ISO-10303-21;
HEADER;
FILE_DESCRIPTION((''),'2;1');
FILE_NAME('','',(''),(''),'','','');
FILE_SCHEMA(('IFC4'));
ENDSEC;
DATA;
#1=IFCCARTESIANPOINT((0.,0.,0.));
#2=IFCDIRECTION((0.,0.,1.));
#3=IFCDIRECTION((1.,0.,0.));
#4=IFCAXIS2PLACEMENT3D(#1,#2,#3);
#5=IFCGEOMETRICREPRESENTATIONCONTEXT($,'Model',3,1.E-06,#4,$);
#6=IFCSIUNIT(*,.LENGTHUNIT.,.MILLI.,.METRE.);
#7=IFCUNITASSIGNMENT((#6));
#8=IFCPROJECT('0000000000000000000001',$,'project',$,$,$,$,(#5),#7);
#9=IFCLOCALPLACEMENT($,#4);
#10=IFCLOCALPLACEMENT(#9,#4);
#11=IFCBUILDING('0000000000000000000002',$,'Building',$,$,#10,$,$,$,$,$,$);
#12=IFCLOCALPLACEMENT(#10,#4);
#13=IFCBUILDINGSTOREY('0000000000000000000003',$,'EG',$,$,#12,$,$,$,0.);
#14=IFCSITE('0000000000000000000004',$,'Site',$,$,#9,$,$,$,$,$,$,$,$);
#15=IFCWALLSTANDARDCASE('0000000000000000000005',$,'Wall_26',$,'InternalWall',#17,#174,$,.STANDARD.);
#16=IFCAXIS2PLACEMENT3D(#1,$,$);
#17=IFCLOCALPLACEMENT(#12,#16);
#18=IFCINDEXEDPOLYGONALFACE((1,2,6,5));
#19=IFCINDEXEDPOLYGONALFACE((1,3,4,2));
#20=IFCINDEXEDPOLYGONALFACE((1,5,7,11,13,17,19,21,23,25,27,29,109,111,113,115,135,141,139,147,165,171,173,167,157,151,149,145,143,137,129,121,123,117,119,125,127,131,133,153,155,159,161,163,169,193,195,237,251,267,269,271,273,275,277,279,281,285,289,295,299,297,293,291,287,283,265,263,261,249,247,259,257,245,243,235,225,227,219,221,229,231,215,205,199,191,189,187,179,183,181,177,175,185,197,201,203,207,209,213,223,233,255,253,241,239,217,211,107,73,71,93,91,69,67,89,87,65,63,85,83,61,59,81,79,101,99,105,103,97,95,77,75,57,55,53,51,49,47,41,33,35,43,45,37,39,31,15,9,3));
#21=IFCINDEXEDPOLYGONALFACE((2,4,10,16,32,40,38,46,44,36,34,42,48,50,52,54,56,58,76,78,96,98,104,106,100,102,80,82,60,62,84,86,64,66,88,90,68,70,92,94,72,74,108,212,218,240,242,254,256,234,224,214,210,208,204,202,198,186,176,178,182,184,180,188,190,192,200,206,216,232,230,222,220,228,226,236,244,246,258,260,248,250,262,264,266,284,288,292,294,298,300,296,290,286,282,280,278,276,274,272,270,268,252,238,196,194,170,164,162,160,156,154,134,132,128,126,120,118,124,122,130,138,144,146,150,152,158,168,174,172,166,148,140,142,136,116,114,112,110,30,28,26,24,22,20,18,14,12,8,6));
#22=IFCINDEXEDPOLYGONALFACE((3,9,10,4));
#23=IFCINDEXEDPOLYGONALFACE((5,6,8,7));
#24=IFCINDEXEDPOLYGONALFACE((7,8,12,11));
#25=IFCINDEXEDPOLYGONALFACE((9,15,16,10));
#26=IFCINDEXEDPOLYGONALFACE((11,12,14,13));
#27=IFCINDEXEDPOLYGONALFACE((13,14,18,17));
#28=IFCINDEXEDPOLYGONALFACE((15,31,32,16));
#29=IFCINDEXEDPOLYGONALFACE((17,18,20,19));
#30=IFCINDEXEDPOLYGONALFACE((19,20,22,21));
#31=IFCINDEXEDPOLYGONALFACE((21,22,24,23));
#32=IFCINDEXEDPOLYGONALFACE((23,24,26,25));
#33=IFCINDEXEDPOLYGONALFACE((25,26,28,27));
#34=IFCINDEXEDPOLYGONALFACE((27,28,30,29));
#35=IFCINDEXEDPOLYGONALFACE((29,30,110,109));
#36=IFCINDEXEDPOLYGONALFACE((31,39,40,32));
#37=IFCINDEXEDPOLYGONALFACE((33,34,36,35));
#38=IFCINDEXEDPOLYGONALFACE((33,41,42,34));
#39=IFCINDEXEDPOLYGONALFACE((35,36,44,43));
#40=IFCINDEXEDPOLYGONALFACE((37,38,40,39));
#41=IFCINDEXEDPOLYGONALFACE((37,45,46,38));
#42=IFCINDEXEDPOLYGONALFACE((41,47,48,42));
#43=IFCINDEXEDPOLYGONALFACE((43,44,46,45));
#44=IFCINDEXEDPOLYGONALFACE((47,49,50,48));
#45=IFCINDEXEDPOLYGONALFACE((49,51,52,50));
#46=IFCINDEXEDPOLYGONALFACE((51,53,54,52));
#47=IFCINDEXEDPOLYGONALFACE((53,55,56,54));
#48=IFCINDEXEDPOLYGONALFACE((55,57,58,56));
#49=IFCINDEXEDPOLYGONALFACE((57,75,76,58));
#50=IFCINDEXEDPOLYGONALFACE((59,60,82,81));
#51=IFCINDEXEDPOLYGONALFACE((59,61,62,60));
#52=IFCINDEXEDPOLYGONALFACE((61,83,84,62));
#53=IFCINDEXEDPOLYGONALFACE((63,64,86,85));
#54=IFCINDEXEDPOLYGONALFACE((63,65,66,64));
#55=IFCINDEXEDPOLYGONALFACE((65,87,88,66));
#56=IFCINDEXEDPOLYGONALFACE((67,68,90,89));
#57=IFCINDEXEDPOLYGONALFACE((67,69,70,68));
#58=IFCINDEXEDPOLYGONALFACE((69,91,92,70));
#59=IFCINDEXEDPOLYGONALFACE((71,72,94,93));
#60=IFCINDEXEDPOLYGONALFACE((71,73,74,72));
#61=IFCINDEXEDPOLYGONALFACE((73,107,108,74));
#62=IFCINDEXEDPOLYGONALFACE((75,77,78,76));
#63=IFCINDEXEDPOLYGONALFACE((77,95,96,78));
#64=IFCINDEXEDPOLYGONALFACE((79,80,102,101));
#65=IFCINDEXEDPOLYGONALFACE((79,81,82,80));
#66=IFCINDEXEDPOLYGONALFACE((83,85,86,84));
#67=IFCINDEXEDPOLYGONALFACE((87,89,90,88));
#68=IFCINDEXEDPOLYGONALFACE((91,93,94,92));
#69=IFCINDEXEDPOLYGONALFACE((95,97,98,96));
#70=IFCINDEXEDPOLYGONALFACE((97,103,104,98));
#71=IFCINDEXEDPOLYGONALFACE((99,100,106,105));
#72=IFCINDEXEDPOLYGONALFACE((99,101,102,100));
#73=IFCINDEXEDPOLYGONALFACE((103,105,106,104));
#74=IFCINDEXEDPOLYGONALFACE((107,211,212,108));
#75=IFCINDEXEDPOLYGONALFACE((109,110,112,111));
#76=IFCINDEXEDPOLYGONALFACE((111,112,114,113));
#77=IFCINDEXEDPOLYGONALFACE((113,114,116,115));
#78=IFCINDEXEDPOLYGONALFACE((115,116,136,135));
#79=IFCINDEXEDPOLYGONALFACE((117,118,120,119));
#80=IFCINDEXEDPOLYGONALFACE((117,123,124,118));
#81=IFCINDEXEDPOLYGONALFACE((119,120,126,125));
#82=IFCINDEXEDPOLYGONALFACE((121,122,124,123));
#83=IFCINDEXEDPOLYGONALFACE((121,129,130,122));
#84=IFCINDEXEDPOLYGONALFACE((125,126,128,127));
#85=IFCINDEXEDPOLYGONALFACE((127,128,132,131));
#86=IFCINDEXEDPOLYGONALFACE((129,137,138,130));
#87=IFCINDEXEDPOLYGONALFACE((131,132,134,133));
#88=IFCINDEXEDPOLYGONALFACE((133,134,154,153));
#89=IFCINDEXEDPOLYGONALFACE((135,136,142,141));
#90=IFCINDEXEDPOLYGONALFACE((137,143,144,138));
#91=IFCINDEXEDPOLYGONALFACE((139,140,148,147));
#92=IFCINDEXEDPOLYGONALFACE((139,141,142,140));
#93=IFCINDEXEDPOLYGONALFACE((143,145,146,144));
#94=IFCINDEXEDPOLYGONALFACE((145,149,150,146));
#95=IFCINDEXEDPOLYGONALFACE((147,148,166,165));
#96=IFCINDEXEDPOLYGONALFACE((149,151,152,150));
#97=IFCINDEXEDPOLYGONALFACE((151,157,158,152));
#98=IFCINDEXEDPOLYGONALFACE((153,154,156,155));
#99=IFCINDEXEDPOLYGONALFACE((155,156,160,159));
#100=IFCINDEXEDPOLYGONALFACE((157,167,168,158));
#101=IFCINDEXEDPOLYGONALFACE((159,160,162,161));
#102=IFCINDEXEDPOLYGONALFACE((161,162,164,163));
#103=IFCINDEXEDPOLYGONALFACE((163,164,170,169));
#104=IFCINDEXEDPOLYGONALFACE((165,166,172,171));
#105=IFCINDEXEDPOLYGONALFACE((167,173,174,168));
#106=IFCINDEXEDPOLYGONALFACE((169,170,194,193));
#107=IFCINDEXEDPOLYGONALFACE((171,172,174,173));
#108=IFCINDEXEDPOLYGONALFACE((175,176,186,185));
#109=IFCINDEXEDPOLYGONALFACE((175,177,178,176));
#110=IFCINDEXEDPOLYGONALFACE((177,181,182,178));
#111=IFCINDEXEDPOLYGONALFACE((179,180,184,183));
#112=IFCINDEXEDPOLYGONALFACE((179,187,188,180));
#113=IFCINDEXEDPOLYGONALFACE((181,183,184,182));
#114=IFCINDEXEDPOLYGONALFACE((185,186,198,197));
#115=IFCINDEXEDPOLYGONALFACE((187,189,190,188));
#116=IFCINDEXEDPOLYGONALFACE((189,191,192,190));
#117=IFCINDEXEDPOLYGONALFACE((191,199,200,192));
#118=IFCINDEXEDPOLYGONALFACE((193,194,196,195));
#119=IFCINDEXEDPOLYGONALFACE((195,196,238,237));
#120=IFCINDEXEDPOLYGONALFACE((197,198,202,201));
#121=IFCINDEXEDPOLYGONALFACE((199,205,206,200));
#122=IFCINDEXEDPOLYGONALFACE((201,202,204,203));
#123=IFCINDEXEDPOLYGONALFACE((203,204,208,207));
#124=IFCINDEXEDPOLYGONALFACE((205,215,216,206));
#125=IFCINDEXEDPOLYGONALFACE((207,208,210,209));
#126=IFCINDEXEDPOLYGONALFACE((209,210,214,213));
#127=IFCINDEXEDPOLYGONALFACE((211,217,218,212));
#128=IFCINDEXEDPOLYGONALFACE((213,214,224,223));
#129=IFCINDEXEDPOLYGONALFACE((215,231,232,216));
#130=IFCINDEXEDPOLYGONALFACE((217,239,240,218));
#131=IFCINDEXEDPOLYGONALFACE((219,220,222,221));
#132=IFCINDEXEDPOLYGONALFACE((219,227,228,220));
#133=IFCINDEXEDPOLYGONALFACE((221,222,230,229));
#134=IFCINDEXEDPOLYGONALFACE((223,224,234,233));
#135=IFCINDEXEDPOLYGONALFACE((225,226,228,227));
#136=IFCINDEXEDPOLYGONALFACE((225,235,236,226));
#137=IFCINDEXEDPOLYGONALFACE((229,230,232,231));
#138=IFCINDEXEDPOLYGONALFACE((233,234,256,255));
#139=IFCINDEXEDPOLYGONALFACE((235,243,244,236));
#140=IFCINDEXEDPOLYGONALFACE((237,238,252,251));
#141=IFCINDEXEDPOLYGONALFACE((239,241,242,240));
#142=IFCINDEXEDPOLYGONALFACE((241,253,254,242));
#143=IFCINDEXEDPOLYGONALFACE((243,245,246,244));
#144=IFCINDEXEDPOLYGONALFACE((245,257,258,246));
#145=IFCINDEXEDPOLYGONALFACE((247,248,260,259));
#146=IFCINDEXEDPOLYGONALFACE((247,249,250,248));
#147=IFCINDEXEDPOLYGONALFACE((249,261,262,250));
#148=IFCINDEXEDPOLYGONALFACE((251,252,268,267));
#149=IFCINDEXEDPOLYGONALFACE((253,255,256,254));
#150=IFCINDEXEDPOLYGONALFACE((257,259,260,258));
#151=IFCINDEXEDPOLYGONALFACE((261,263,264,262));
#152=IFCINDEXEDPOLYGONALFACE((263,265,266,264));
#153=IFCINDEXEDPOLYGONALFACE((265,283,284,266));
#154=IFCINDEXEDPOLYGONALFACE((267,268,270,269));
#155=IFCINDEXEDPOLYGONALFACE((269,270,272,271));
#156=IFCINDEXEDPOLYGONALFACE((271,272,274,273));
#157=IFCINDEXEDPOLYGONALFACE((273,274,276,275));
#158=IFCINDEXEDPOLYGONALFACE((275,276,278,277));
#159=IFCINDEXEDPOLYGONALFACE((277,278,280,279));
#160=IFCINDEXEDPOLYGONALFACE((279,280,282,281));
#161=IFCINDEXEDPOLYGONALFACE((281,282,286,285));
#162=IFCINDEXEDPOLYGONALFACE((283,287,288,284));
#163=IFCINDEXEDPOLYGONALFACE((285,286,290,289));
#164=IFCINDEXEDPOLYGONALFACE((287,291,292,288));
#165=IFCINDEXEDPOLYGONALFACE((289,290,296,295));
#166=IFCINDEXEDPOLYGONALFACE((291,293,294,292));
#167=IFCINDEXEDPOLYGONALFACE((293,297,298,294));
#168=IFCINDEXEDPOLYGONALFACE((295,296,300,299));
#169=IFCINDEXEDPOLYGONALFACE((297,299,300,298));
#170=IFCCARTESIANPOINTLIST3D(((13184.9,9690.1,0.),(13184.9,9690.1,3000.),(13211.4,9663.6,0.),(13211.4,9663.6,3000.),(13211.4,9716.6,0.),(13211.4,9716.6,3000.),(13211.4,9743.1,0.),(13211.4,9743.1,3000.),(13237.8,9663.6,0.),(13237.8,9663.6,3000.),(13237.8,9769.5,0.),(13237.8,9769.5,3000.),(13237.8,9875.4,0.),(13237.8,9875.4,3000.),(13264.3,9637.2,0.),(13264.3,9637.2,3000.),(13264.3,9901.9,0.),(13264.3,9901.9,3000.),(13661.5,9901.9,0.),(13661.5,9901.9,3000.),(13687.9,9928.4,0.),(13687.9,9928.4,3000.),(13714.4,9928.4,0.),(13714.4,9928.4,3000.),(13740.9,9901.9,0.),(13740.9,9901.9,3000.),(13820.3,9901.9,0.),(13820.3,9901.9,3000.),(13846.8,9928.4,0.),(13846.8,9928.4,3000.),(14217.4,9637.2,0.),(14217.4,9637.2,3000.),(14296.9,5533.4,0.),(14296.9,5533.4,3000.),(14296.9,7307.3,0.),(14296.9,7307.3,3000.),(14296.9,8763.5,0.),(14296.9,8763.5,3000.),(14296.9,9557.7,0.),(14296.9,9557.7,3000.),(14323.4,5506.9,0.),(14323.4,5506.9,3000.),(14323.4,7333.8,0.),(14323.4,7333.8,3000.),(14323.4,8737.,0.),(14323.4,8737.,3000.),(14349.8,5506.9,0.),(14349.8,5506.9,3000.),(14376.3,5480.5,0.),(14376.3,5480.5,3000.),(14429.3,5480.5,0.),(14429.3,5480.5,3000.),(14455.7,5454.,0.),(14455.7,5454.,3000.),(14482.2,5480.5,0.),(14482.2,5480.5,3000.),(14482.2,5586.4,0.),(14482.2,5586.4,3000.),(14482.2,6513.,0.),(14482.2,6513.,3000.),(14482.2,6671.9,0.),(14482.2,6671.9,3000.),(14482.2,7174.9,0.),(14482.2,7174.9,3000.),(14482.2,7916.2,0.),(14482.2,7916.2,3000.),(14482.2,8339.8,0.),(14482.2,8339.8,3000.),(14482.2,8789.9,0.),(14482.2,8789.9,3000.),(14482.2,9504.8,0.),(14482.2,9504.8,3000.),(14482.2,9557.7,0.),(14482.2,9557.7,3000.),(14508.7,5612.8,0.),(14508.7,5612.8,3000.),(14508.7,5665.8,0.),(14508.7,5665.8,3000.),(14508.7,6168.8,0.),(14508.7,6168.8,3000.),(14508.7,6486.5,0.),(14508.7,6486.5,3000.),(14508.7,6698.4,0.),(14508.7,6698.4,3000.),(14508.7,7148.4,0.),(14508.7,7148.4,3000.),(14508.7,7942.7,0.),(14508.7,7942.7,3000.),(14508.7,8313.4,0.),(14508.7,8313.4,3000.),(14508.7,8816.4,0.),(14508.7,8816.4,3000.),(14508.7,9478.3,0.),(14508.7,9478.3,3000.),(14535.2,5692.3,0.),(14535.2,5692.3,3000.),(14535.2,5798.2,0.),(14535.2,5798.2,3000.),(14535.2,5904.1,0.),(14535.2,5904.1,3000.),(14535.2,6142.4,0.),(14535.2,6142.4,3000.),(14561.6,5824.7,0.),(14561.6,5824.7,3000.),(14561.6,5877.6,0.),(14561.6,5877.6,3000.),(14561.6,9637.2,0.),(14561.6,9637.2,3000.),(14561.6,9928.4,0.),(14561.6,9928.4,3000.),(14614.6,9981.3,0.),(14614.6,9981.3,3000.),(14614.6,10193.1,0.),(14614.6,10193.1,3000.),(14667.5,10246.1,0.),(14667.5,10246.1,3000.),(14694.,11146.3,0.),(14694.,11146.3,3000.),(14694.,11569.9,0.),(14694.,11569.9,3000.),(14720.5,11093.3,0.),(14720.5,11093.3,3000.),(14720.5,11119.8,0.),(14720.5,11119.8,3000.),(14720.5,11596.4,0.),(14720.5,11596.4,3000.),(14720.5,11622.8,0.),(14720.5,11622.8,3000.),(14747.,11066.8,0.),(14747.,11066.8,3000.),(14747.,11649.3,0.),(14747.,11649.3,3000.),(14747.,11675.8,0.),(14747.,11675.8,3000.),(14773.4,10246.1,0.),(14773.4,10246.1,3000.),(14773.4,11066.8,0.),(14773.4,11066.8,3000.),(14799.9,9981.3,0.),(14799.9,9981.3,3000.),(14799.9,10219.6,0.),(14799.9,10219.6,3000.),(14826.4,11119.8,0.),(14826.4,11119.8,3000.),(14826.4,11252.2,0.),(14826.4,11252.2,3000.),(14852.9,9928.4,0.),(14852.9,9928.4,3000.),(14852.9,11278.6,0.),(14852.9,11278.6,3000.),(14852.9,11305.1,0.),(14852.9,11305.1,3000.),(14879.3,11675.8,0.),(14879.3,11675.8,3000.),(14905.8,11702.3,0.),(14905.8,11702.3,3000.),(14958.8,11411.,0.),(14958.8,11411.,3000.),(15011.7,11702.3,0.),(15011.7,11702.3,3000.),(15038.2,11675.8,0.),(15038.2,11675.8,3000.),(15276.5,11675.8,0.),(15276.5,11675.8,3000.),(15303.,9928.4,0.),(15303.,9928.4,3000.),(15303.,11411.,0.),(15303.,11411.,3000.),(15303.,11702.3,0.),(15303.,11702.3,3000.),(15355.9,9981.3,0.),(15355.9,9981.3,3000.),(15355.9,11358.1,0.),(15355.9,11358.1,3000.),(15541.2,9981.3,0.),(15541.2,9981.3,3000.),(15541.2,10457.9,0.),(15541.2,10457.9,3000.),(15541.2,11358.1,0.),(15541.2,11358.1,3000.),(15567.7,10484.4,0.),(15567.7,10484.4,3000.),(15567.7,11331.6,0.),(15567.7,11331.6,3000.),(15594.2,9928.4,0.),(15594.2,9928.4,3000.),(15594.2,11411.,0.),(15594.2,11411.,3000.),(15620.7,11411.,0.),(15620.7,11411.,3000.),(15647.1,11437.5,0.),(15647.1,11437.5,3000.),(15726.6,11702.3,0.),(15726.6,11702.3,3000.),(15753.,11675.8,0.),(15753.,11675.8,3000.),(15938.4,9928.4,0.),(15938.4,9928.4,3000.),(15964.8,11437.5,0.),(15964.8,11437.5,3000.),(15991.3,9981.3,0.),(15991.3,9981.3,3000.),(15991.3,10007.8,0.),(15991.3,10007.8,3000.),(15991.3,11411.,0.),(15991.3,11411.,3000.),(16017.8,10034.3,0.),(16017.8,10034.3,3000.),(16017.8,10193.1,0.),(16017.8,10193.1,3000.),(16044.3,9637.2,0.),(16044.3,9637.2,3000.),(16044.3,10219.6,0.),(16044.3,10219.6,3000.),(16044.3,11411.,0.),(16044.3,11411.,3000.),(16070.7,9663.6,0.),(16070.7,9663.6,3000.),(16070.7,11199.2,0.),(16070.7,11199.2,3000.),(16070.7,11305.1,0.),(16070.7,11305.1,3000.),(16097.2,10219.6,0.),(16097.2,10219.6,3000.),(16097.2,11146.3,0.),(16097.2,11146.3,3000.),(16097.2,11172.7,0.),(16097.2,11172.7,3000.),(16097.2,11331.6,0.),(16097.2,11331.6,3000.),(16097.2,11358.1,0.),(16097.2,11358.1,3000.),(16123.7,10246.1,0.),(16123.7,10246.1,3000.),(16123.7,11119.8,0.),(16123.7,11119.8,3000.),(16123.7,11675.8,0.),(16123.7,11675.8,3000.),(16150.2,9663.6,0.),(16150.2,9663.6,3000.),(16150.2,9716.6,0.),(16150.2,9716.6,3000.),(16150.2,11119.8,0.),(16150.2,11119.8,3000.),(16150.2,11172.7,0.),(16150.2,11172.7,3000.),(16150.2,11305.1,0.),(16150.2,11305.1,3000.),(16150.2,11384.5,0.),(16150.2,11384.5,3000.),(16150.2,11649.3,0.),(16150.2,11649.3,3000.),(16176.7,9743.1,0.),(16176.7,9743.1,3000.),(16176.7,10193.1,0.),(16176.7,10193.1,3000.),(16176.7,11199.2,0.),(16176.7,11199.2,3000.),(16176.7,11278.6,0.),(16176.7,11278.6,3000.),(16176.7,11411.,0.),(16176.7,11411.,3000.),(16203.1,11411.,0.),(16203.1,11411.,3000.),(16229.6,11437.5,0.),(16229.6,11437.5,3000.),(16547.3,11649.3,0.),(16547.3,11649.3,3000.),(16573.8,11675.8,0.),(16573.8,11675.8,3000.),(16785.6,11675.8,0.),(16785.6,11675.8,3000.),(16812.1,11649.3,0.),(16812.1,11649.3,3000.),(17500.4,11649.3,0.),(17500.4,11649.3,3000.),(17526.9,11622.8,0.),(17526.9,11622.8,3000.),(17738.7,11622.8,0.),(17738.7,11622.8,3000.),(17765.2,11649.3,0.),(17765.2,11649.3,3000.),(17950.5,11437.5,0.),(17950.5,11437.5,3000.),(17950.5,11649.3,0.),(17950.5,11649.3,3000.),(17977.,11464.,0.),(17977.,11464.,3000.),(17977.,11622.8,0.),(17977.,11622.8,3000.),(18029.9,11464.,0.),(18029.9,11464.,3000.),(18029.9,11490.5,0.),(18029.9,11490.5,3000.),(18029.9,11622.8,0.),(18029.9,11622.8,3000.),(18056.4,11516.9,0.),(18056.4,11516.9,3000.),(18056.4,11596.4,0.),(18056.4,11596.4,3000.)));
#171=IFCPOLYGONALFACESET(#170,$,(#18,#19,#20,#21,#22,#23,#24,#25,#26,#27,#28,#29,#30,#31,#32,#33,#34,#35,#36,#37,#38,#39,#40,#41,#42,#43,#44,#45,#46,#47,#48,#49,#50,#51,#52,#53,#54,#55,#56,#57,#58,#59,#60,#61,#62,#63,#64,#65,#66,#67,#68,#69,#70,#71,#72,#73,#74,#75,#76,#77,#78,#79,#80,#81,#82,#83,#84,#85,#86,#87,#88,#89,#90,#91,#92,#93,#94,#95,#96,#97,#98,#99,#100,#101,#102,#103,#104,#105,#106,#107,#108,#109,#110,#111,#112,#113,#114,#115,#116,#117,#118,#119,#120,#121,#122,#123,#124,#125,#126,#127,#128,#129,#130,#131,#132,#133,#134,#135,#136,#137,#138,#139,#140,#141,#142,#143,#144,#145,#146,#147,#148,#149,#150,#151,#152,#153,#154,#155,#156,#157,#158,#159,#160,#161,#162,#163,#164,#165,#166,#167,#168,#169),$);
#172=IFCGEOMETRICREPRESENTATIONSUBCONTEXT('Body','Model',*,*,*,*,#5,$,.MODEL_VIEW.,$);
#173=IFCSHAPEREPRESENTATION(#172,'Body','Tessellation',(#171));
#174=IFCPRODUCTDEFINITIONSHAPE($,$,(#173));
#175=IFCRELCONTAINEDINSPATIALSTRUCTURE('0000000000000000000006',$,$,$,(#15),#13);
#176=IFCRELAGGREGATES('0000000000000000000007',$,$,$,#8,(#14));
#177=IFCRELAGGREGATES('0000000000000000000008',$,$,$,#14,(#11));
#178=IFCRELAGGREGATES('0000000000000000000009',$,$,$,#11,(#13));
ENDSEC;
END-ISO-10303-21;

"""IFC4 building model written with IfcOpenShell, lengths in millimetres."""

from ifc_helpers import new_model, si_unit, origin_with_axes, place, context, subcontext, project, spatial, polyline, outline, extrude, element, save


model = new_model("IFC4")

# Units and contexts
model_context = context("Model", 3, precision=1e-06, world=origin_with_axes())
body_context = subcontext(model_context, "Body", "Model", "MODEL_VIEW")
ifc_project = project(units=[si_unit("LENGTHUNIT", "METRE", prefix="MILLI")], contexts=[model_context])

# Site, building, storey
site_placement = place(None, origin_with_axes())
site = spatial("IfcSite", under=ifc_project, at=site_placement, Name="Site")
building_placement = place(site_placement, origin_with_axes())
building = spatial("IfcBuilding", under=site, at=building_placement, Name="Building")
storey_placement = place(building_placement, origin_with_axes())
storey = spatial("IfcBuildingStorey", under=building, at=storey_placement, Name="EG", Elevation=0.0)

# Wall
wall_1_placement = place(storey_placement, origin_with_axes())
element("IfcWallStandardCase", 1, at=wall_1_placement, inside=storey, Name="Wall_26", ObjectType="InternalWall", PredefinedType="STANDARD", context=body_context, shape_type="SweptSolid", body=[
    extrude(outline(polyline([(14455.7, 5454.0, 0.0), (14429.3, 5480.5, 0.0), (14376.3, 5480.5, 0.0), (14349.8, 5506.9, 0.0), (14323.4, 5506.9, 0.0), (14296.9, 5533.4, 0.0), (14296.9, 7307.3, 0.0), (14323.4, 7333.8, 0.0), (14323.4, 8737.0, 0.0), (14296.9, 8763.5, 0.0), (14296.9, 9557.7, 0.0), (14217.4, 9637.2, 0.0), (13264.3, 9637.2, 0.0), (13237.8, 9663.6, 0.0), (13211.4, 9663.6, 0.0), (13184.9, 9690.1, 0.0), (13211.4, 9716.6, 0.0), (13211.4, 9743.1, 0.0), (13237.8, 9769.5, 0.0), (13237.8, 9875.4, 0.0), (13264.3, 9901.9, 0.0), (13661.5, 9901.9, 0.0), (13687.9, 9928.4, 0.0), (13714.4, 9928.4, 0.0), (13740.9, 9901.9, 0.0), (13820.3, 9901.9, 0.0), (13846.8, 9928.4, 0.0), (14561.6, 9928.4, 0.0), (14614.6, 9981.3, 0.0), (14614.6, 10193.1, 0.0), (14667.5, 10246.1, 0.0), (14773.4, 10246.1, 0.0), (14799.9, 10219.6, 0.0), (14799.9, 9981.3, 0.0), (14852.9, 9928.4, 0.0), (15303.0, 9928.4, 0.0), (15355.9, 9981.3, 0.0), (15355.9, 11358.1, 0.0), (15303.0, 11411.0, 0.0), (14958.8, 11411.0, 0.0), (14852.9, 11305.1, 0.0), (14852.9, 11278.6, 0.0), (14826.4, 11252.2, 0.0), (14826.4, 11119.8, 0.0), (14773.4, 11066.8, 0.0), (14747.0, 11066.8, 0.0), (14720.5, 11093.3, 0.0), (14720.5, 11119.8, 0.0), (14694.0, 11146.3, 0.0), (14694.0, 11569.9, 0.0), (14720.5, 11596.4, 0.0), (14720.5, 11622.8, 0.0), (14747.0, 11649.3, 0.0), (14747.0, 11675.8, 0.0), (14879.3, 11675.8, 0.0), (14905.8, 11702.3, 0.0), (15011.7, 11702.3, 0.0), (15038.2, 11675.8, 0.0), (15276.5, 11675.8, 0.0), (15303.0, 11702.3, 0.0), (15726.6, 11702.3, 0.0), (15753.0, 11675.8, 0.0), (16123.7, 11675.8, 0.0), (16150.2, 11649.3, 0.0), (16547.3, 11649.3, 0.0), (16573.8, 11675.8, 0.0), (16785.6, 11675.8, 0.0), (16812.1, 11649.3, 0.0), (17500.4, 11649.3, 0.0), (17526.9, 11622.8, 0.0), (17738.7, 11622.8, 0.0), (17765.2, 11649.3, 0.0), (17950.5, 11649.3, 0.0), (17977.0, 11622.8, 0.0), (18029.9, 11622.8, 0.0), (18056.4, 11596.4, 0.0), (18056.4, 11516.9, 0.0), (18029.9, 11490.5, 0.0), (18029.9, 11464.0, 0.0), (17977.0, 11464.0, 0.0), (17950.5, 11437.5, 0.0), (16229.6, 11437.5, 0.0), (16203.1, 11411.0, 0.0), (16176.7, 11411.0, 0.0), (16150.2, 11384.5, 0.0), (16150.2, 11305.1, 0.0), (16176.7, 11278.6, 0.0), (16176.7, 11199.2, 0.0), (16150.2, 11172.7, 0.0), (16150.2, 11119.8, 0.0), (16123.7, 11119.8, 0.0), (16097.2, 11146.3, 0.0), (16097.2, 11172.7, 0.0), (16070.7, 11199.2, 0.0), (16070.7, 11305.1, 0.0), (16097.2, 11331.6, 0.0), (16097.2, 11358.1, 0.0), (16044.3, 11411.0, 0.0), (15991.3, 11411.0, 0.0), (15964.8, 11437.5, 0.0), (15647.1, 11437.5, 0.0), (15620.7, 11411.0, 0.0), (15594.2, 11411.0, 0.0), (15541.2, 11358.1, 0.0), (15567.7, 11331.6, 0.0), (15567.7, 10484.4, 0.0), (15541.2, 10457.9, 0.0), (15541.2, 9981.3, 0.0), (15594.2, 9928.4, 0.0), (15938.4, 9928.4, 0.0), (15991.3, 9981.3, 0.0), (15991.3, 10007.8, 0.0), (16017.8, 10034.3, 0.0), (16017.8, 10193.1, 0.0), (16044.3, 10219.6, 0.0), (16097.2, 10219.6, 0.0), (16123.7, 10246.1, 0.0), (16176.7, 10193.1, 0.0), (16176.7, 9743.1, 0.0), (16150.2, 9716.6, 0.0), (16150.2, 9663.6, 0.0), (16070.7, 9663.6, 0.0), (16044.3, 9637.2, 0.0), (14561.6, 9637.2, 0.0), (14482.2, 9557.7, 0.0), (14482.2, 9504.8, 0.0), (14508.7, 9478.3, 0.0), (14508.7, 8816.4, 0.0), (14482.2, 8789.9, 0.0), (14482.2, 8339.8, 0.0), (14508.7, 8313.4, 0.0), (14508.7, 7942.7, 0.0), (14482.2, 7916.2, 0.0), (14482.2, 7174.9, 0.0), (14508.7, 7148.4, 0.0), (14508.7, 6698.4, 0.0), (14482.2, 6671.9, 0.0), (14482.2, 6513.0, 0.0), (14508.7, 6486.5, 0.0), (14508.7, 6168.8, 0.0), (14535.2, 6142.4, 0.0), (14535.2, 5904.1, 0.0), (14561.6, 5877.6, 0.0), (14561.6, 5824.7, 0.0), (14535.2, 5798.2, 0.0), (14535.2, 5692.3, 0.0), (14508.7, 5665.8, 0.0), (14508.7, 5612.8, 0.0), (14482.2, 5586.4, 0.0), (14482.2, 5480.5, 0.0), (14455.7, 5454.0, 0.0)])), origin_with_axes(), (0.0, 0.0, 1.0), 3000.0),
])

save(model, "model.ifc")
